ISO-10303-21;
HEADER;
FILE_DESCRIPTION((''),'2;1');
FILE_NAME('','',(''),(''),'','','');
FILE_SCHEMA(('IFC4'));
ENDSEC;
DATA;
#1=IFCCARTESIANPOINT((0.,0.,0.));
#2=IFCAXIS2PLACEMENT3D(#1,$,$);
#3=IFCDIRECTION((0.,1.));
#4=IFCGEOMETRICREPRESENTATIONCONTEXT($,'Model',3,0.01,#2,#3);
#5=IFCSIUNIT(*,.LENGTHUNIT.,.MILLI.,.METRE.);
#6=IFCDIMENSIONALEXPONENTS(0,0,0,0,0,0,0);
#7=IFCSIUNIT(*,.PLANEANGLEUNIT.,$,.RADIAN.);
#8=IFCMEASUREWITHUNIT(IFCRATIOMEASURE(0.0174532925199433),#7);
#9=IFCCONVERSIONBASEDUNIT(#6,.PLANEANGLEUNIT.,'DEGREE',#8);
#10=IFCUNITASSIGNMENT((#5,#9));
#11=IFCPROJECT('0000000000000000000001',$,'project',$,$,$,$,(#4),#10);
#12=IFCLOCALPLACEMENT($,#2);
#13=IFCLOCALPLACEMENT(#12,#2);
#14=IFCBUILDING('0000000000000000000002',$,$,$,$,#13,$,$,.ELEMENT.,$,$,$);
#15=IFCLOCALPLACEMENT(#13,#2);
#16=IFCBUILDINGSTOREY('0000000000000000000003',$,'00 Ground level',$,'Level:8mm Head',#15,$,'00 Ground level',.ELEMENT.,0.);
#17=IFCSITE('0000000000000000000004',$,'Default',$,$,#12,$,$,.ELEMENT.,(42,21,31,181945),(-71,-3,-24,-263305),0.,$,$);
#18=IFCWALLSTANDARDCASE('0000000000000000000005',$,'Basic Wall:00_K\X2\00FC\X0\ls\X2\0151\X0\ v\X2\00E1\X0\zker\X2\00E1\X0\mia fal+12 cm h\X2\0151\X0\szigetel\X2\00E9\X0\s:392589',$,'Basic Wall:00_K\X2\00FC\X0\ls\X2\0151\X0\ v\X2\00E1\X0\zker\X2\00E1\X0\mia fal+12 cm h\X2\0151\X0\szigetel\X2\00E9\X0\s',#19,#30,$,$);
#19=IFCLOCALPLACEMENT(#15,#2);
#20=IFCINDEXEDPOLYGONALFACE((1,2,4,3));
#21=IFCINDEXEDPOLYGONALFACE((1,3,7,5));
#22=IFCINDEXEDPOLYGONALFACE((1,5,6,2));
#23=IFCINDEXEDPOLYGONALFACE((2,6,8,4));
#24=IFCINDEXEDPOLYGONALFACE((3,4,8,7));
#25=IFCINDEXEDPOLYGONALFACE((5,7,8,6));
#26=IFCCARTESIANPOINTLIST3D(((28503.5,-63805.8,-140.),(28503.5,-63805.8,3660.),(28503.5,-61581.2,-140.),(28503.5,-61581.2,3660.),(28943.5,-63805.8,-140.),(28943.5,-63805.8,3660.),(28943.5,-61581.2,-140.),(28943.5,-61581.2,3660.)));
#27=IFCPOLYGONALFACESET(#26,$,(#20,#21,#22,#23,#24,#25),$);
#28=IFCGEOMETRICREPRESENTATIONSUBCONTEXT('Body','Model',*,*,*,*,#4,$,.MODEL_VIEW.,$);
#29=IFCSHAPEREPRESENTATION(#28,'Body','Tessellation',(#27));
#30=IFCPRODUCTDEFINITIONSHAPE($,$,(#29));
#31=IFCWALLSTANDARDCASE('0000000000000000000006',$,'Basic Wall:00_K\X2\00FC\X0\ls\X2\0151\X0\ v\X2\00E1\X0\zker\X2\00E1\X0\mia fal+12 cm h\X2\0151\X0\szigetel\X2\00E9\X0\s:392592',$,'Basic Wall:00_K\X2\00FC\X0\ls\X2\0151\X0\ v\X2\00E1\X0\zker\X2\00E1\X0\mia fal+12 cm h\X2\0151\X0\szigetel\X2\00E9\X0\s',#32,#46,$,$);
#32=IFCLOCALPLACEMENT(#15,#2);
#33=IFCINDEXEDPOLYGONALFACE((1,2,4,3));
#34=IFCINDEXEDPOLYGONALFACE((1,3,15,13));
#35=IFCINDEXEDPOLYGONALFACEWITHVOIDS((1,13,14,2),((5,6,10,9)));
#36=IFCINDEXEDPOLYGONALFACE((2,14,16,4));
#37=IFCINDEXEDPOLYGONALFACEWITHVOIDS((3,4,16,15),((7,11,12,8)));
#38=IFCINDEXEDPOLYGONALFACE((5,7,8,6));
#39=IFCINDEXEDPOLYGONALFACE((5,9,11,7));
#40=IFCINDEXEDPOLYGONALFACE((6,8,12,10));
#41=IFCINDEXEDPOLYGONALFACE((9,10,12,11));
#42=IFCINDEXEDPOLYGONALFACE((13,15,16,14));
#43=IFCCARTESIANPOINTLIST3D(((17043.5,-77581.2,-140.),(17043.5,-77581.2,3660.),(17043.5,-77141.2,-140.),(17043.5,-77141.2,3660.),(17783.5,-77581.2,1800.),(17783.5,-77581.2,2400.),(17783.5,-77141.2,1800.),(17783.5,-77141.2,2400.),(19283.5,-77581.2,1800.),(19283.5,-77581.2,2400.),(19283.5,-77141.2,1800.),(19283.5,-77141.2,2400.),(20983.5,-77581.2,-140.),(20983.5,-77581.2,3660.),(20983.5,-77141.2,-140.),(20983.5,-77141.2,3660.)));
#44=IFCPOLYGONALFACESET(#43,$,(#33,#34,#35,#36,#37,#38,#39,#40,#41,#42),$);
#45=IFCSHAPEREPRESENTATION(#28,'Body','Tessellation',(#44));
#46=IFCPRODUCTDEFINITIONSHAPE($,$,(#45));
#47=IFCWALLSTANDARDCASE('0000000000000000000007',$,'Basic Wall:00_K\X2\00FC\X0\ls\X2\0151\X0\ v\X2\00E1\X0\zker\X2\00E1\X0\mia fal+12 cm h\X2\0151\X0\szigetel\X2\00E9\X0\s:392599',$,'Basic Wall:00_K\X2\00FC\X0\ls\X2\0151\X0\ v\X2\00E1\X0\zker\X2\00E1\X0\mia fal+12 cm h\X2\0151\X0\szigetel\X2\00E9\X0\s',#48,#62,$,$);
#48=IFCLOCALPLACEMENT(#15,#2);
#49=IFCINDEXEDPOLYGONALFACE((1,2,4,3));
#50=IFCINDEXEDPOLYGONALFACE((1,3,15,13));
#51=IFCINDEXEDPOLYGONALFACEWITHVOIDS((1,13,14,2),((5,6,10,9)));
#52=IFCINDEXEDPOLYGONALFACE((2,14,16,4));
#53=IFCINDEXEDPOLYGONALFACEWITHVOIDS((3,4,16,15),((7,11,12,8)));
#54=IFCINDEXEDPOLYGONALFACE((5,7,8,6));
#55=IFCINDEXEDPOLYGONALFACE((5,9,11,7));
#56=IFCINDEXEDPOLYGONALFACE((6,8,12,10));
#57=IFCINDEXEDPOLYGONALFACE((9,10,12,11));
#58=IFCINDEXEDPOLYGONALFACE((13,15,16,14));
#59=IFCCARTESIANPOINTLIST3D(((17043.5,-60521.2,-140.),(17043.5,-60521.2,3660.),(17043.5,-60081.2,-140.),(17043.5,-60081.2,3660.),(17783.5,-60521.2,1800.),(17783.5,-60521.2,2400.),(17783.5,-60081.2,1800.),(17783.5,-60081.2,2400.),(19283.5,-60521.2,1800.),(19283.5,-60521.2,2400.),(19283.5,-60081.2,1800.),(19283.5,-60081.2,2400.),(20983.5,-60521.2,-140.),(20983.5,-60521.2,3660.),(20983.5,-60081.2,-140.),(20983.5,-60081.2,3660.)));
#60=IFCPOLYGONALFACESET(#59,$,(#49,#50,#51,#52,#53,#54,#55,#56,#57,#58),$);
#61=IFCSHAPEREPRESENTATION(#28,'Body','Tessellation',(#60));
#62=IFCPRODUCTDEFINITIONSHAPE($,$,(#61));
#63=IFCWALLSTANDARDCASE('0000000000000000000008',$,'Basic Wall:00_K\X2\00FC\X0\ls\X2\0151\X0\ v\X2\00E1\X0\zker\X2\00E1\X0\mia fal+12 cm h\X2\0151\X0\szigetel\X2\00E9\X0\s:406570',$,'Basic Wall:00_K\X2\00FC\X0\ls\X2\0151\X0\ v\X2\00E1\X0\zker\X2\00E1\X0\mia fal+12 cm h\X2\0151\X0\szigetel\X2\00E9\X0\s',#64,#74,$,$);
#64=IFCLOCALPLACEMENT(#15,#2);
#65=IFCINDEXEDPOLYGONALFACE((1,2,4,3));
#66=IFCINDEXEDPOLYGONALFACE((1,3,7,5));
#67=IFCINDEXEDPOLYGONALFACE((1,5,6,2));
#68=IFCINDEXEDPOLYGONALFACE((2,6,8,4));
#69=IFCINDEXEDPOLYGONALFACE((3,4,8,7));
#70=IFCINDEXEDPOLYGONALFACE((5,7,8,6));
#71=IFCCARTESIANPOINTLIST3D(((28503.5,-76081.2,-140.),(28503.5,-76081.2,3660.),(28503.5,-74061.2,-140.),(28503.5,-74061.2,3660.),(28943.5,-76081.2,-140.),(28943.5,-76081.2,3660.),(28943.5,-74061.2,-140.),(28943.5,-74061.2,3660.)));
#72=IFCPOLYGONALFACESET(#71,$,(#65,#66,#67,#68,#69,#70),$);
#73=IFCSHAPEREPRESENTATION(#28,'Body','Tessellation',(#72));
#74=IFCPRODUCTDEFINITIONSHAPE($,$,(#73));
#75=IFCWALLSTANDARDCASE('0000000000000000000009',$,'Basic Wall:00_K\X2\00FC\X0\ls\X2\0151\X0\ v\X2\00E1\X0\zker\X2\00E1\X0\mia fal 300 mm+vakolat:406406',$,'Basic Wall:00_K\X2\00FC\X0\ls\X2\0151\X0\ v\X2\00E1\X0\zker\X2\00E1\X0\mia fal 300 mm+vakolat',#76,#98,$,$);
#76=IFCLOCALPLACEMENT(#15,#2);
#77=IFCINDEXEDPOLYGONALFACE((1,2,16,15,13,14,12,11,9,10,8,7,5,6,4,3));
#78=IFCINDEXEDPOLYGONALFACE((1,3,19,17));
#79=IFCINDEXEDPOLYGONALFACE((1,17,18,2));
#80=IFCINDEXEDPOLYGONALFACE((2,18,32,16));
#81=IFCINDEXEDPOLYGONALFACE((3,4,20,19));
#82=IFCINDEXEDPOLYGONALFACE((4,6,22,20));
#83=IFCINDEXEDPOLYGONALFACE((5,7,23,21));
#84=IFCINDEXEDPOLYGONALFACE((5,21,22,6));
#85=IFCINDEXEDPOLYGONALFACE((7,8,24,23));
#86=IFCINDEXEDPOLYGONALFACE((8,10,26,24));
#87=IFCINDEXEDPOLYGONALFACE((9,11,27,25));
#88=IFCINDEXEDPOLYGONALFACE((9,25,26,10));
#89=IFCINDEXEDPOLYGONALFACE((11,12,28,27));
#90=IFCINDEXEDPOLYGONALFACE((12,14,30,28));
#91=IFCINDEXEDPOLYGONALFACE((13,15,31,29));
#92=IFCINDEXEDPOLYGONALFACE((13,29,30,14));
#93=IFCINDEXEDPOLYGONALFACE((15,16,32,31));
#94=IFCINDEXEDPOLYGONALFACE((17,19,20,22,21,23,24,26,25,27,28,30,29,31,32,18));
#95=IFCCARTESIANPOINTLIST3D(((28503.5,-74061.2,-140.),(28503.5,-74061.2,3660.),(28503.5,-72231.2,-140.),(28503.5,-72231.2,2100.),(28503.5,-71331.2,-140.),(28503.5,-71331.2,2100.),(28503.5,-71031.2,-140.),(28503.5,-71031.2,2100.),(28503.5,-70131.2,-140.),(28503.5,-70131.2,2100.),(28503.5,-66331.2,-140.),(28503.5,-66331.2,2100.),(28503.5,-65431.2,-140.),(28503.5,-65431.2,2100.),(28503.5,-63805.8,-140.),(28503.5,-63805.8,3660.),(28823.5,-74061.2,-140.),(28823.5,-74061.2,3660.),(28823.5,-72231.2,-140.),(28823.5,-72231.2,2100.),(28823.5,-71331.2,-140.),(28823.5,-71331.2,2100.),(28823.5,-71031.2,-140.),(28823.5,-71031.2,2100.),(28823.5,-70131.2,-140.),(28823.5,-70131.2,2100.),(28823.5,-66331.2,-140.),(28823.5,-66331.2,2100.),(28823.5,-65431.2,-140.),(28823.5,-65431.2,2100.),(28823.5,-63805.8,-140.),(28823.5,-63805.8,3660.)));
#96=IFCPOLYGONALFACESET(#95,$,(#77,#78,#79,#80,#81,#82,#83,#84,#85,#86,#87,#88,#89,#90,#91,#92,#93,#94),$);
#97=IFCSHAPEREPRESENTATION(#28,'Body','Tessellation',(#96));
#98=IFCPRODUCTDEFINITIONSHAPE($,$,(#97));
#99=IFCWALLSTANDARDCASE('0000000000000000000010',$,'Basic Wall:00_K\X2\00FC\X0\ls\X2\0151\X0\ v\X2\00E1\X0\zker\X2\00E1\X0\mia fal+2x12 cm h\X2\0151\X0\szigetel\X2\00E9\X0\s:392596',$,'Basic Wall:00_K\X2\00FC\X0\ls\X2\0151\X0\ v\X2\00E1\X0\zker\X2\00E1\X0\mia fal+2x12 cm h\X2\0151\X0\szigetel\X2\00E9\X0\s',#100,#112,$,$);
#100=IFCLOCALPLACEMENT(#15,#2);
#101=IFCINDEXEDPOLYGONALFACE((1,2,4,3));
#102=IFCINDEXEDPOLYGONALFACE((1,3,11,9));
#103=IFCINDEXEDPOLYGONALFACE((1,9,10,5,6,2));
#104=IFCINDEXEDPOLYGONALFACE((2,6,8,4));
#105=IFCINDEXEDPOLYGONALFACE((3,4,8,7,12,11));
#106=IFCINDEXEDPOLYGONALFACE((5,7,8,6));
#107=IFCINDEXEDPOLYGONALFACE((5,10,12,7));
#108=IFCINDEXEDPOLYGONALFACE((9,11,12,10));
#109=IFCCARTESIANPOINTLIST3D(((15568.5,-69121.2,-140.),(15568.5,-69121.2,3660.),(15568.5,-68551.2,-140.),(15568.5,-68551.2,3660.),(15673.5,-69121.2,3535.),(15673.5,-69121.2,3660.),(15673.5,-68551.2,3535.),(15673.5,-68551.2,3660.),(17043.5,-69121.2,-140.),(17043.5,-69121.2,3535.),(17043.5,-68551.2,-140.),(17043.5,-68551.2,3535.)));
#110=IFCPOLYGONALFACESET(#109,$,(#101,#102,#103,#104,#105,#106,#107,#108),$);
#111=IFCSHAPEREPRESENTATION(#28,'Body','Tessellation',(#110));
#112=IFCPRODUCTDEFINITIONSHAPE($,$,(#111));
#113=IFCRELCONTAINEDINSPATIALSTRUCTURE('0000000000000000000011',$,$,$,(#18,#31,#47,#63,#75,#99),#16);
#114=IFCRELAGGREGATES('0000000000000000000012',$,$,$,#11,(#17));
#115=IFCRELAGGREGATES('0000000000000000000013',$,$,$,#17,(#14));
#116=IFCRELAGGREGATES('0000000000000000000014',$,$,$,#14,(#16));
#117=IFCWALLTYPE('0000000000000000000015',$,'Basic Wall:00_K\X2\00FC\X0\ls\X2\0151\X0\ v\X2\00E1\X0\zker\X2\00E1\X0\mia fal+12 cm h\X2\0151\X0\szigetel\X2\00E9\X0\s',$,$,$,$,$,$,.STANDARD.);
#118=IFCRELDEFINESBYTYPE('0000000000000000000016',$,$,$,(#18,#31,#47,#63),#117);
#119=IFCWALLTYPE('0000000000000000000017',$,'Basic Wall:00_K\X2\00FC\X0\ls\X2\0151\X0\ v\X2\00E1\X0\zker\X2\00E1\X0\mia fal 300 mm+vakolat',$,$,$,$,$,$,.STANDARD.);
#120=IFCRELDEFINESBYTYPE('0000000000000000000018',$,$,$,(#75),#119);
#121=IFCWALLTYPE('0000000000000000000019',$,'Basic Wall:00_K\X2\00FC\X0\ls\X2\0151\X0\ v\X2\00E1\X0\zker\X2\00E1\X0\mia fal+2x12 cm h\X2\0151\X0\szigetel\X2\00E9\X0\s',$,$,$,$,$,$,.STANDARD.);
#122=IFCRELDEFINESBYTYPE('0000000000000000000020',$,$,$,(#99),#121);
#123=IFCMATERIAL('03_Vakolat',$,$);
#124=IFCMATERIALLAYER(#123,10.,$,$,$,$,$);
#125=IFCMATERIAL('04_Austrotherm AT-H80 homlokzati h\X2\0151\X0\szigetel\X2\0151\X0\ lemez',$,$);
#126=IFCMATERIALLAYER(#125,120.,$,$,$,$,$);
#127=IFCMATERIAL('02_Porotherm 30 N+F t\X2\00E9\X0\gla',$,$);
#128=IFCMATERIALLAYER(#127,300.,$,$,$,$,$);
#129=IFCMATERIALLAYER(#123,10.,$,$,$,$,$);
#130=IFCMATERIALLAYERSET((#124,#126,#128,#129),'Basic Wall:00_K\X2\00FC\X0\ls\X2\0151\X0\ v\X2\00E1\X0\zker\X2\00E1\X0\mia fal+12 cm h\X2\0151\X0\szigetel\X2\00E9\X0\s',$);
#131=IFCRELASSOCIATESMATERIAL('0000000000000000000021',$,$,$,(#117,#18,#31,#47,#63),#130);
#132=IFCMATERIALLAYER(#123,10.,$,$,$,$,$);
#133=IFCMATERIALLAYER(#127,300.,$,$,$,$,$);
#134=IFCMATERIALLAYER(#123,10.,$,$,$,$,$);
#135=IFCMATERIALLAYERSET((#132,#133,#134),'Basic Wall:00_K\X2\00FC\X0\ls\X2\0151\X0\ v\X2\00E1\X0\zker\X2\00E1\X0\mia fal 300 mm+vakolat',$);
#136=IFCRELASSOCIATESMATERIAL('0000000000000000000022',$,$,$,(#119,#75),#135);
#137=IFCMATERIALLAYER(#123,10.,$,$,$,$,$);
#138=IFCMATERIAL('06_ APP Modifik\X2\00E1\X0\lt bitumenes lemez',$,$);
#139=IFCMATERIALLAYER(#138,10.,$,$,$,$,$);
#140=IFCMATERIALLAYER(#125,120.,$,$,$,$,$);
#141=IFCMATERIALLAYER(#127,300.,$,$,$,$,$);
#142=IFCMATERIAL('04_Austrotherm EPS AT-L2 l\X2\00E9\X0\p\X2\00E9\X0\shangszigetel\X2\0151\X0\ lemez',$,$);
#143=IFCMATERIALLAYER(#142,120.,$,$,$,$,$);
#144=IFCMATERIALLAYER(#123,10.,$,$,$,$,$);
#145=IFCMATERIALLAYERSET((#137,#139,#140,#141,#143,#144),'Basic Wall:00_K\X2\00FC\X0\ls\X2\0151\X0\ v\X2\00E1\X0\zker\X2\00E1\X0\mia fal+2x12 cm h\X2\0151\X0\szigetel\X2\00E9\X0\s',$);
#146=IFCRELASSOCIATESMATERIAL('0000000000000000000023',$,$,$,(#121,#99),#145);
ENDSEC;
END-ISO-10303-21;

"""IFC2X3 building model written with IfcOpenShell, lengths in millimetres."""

from ifc_helpers import new_model, entity, si_unit, converted_unit, direction, frame, frame_2d, origin, origin_2d_with_axis, place, context, subcontext, project, spatial, polyline, rectangle, extrude, clip, bounded_halfspace, material, layer, layer_set, layer_usage, type_object, element, save


model = new_model("IFC2X3")

# Units and contexts
model_context = context("Model", 3, precision=0.01, world=origin(), true_north=direction((0.0, 1.0)))
body_context = subcontext(model_context, "Body", "Model", "MODEL_VIEW")
ifc_project = project(units=[si_unit("LENGTHUNIT", "METRE", prefix="MILLI"), converted_unit("PLANEANGLEUNIT", "DEGREE", entity("IfcRatioMeasure", 0.0174532925199433), si_unit("PLANEANGLEUNIT", "RADIAN"), dimensions=[0, 0, 0, 0, 0, 0, 0])], contexts=[model_context])

# Site, building, storey
site_placement = place(None, origin())
site = spatial("IfcSite", under=ifc_project, at=site_placement, Name="Default", CompositionType="ELEMENT", RefLatitude=(42, 21, 31, 181945), RefLongitude=(-71, -3, -24, -263305), RefElevation=0.0)
building_placement = place(site_placement, origin())
building = spatial("IfcBuilding", under=site, at=building_placement, CompositionType="ELEMENT")
storey_placement = place(building_placement, origin())
storey = spatial("IfcBuildingStorey", under=building, at=storey_placement, Name="00 Ground level", ObjectType="Level:8mm Head", LongName="00 Ground level", CompositionType="ELEMENT", Elevation=0.0)

# Wall
ifc_material_1 = material(Name="03_Vakolat")
ifc_layer_1 = layer(ifc_material_1, 10.0)
ifc_material_2 = material(Name="04_Austrotherm AT-H80 homlokzati hőszigetelő lemez")
ifc_layer_2 = layer(ifc_material_2, 120.0)
ifc_material_3 = material(Name="02_Porotherm 30 N+F tégla")
ifc_layer_3 = layer(ifc_material_3, 300.0)
ifc_layer_4 = layer(ifc_material_1, 10.0)
ifc_layer_set_1 = layer_set([ifc_layer_1, ifc_layer_2, ifc_layer_3, ifc_layer_4], Name="Basic Wall:00_Külső vázkerámia fal+12 cm hőszigetelés")
ifc_layer_usage_1 = layer_usage(ifc_layer_set_1, "AXIS2", "NEGATIVE", 220.0)
wall_type_1 = type_object("IfcWallType", Name="Basic Wall:00_Külső vázkerámia fal+12 cm hőszigetelés", PredefinedType="STANDARD", material=ifc_layer_set_1)
wall_1_placement = place(storey_placement, frame((28723.5, -61581.2, -140.0), z_axis=(0.0, 0.0, 1.0), x_axis=(0.0, -1.0, 0.0)))
element("IfcWallStandardCase", 1, at=wall_1_placement, inside=storey, type_object=wall_type_1, material=ifc_layer_usage_1, Name="Basic Wall:00_Külső vázkerámia fal+12 cm hőszigetelés:392589", ObjectType="Basic Wall:00_Külső vázkerámia fal+12 cm hőszigetelés", context=body_context, shape_type="SweptSolid", body=[
    extrude(rectangle(XDim=2224.6, YDim=440.0, at=frame_2d((1112.3, 0.0), x_axis=(-1.0, 0.0))), origin(), (0.0, 0.0, 1.0), 3800.0),
])

# Walls, openings
ifc_layer_usage_2 = layer_usage(ifc_layer_set_1, "AXIS2", "NEGATIVE", 220.0)
wall_2_placement = place(storey_placement, frame((20983.5, -77361.2, -140.0), z_axis=(0.0, 0.0, 1.0), x_axis=(-1.0, 0.0, 0.0)))
wall_2 = element("IfcWallStandardCase", 2, at=wall_2_placement, inside=storey, type_object=wall_type_1, material=ifc_layer_usage_2, Name="Basic Wall:00_Külső vázkerámia fal+12 cm hőszigetelés:392592", ObjectType="Basic Wall:00_Külső vázkerámia fal+12 cm hőszigetelés", context=body_context, shape_type="SweptSolid", body=[
    extrude(rectangle(XDim=3940.0, YDim=440.0, at=frame_2d((1970.0, 0.0), x_axis=(-1.0, 0.0))), origin(), (0.0, 0.0, 1.0), 3800.0),
])
opening_1_placement = place(wall_2_placement, frame((3200.0, 1744.0, 1940.0), z_axis=(0.0, 0.0, 1.0), x_axis=(-1.0, 0.0, 0.0)))
element("IfcOpeningElement", 3, at=opening_1_placement, cuts=wall_2, ObjectType="Opening", context=body_context, shape_type="SweptSolid", body=[
    extrude(rectangle(XDim=600.0, YDim=1500.0, at=frame_2d((0.0, 0.0), x_axis=(0.0, 1.0))), frame((750.0, 3048.0, 300.0), z_axis=(0.0, -1.0, 0.0), x_axis=(1.0, 0.0, 0.0)), (0.0, 0.0, 1.0), 3048.0),
])
ifc_layer_usage_3 = layer_usage(ifc_layer_set_1, "AXIS2", "POSITIVE", -220.0)
wall_3_placement = place(storey_placement, frame((20983.5, -60301.2, -140.0), z_axis=(0.0, 0.0, 1.0), x_axis=(-1.0, 0.0, 0.0)))
wall_3 = element("IfcWallStandardCase", 4, at=wall_3_placement, inside=storey, type_object=wall_type_1, material=ifc_layer_usage_3, Name="Basic Wall:00_Külső vázkerámia fal+12 cm hőszigetelés:392599", ObjectType="Basic Wall:00_Külső vázkerámia fal+12 cm hőszigetelés", context=body_context, shape_type="SweptSolid", body=[
    extrude(rectangle(XDim=3940.0, YDim=440.0, at=frame_2d((1970.0, 0.0), x_axis=(-1.0, 0.0))), origin(), (0.0, 0.0, 1.0), 3800.0),
])
opening_2_placement = place(wall_3_placement, frame((3200.0, 1304.0, 1940.0), z_axis=(0.0, 0.0, 1.0), x_axis=(-1.0, 0.0, 0.0)))
element("IfcOpeningElement", 5, at=opening_2_placement, cuts=wall_3, ObjectType="Opening", context=body_context, shape_type="SweptSolid", body=[
    extrude(rectangle(XDim=600.0, YDim=1500.0, at=frame_2d((0.0, 0.0), x_axis=(0.0, 1.0))), frame((750.0, 3048.0, 300.0), z_axis=(0.0, -1.0, 0.0), x_axis=(1.0, 0.0, 0.0)), (0.0, 0.0, 1.0), 3048.0),
])

# Wall
ifc_layer_usage_4 = layer_usage(ifc_layer_set_1, "AXIS2", "NEGATIVE", 220.0)
wall_4_placement = place(storey_placement, frame((28723.5, -74061.2, -140.0), z_axis=(0.0, 0.0, 1.0), x_axis=(0.0, -1.0, 0.0)))
element("IfcWallStandardCase", 6, at=wall_4_placement, inside=storey, type_object=wall_type_1, material=ifc_layer_usage_4, Name="Basic Wall:00_Külső vázkerámia fal+12 cm hőszigetelés:406570", ObjectType="Basic Wall:00_Külső vázkerámia fal+12 cm hőszigetelés", context=body_context, shape_type="SweptSolid", body=[
    extrude(rectangle(XDim=2020.0, YDim=440.0, at=frame_2d((1010.0, 0.0), x_axis=(-1.0, 0.0))), origin(), (0.0, 0.0, 1.0), 3800.0),
])

# Wall, openings
ifc_layer_5 = layer(ifc_material_1, 10.0)
ifc_layer_6 = layer(ifc_material_3, 300.0)
ifc_layer_7 = layer(ifc_material_1, 10.0)
ifc_layer_set_2 = layer_set([ifc_layer_5, ifc_layer_6, ifc_layer_7], Name="Basic Wall:00_Külső vázkerámia fal 300 mm+vakolat")
ifc_layer_usage_5 = layer_usage(ifc_layer_set_2, "AXIS2", "NEGATIVE", 160.0)
wall_type_2 = type_object("IfcWallType", Name="Basic Wall:00_Külső vázkerámia fal 300 mm+vakolat", PredefinedType="STANDARD", material=ifc_layer_set_2)
wall_5_placement = place(storey_placement, frame((28663.5, -63805.8, -140.0), z_axis=(0.0, 0.0, 1.0), x_axis=(0.0, -1.0, 0.0)))
wall_5 = element("IfcWallStandardCase", 7, at=wall_5_placement, inside=storey, type_object=wall_type_2, material=ifc_layer_usage_5, Name="Basic Wall:00_Külső vázkerámia fal 300 mm+vakolat:406406", ObjectType="Basic Wall:00_Külső vázkerámia fal 300 mm+vakolat", context=body_context, shape_type="SweptSolid", body=[
    extrude(rectangle(XDim=10255.4, YDim=320.0, at=frame_2d((5127.7, 0.0), x_axis=(-1.0, 0.0))), origin(), (0.0, 0.0, 1.0), 3800.0),
])
opening_3_placement = place(wall_5_placement, frame((8425.4, -1364.0, 0.0), z_axis=(0.0, 0.0, 1.0), x_axis=(0.0, 1.0, 0.0)))
element("IfcOpeningElement", 8, at=opening_3_placement, cuts=wall_5, ObjectType="Opening", context=body_context, shape_type="SweptSolid", body=[
    extrude(rectangle(XDim=2240.0, YDim=900.0, at=frame_2d((0.0, 0.0), x_axis=(0.0, 1.0))), frame((0.0, 450.0, 1120.0), z_axis=(1.0, 0.0, 0.0), x_axis=(0.0, 1.0, 0.0)), (0.0, 0.0, 1.0), 3048.0),
])
opening_4_placement = place(wall_5_placement, frame((7225.4, -1364.0, 0.0), z_axis=(0.0, 0.0, 1.0), x_axis=(0.0, 1.0, 0.0)))
element("IfcOpeningElement", 9, at=opening_4_placement, cuts=wall_5, ObjectType="Opening", context=body_context, shape_type="SweptSolid", body=[
    extrude(rectangle(XDim=2240.0, YDim=900.0, at=origin_2d_with_axis()), frame((0.0, 450.0, 1120.0), z_axis=(1.0, 0.0, 0.0), x_axis=(0.0, 0.0, 1.0)), (0.0, 0.0, 1.0), 3048.0),
])
opening_5_placement = place(wall_5_placement, frame((2525.4, -1364.0, 0.0), z_axis=(0.0, 0.0, 1.0), x_axis=(0.0, 1.0, 0.0)))
element("IfcOpeningElement", 10, at=opening_5_placement, cuts=wall_5, ObjectType="Opening", context=body_context, shape_type="SweptSolid", body=[
    extrude(rectangle(XDim=2240.0, YDim=900.0, at=origin_2d_with_axis()), frame((0.0, 450.0, 1120.0), z_axis=(1.0, 0.0, 0.0), x_axis=(0.0, 0.0, 1.0)), (0.0, 0.0, 1.0), 3048.0),
])

# Wall
ifc_layer_8 = layer(ifc_material_1, 10.0)
ifc_material_4 = material(Name="06_ APP Modifikált bitumenes lemez")
ifc_layer_9 = layer(ifc_material_4, 10.0)
ifc_layer_10 = layer(ifc_material_2, 120.0)
ifc_layer_11 = layer(ifc_material_3, 300.0)
ifc_material_5 = material(Name="04_Austrotherm EPS AT-L2 lépéshangszigetelő lemez")
ifc_layer_12 = layer(ifc_material_5, 120.0)
ifc_layer_13 = layer(ifc_material_1, 10.0)
ifc_layer_set_3 = layer_set([ifc_layer_8, ifc_layer_9, ifc_layer_10, ifc_layer_11, ifc_layer_12, ifc_layer_13], Name="Basic Wall:00_Külső vázkerámia fal+2x12 cm hőszigetelés")
ifc_layer_usage_6 = layer_usage(ifc_layer_set_3, "AXIS2", "NEGATIVE", 285.0)
wall_type_3 = type_object("IfcWallType", Name="Basic Wall:00_Külső vázkerámia fal+2x12 cm hőszigetelés", PredefinedType="STANDARD", material=ifc_layer_set_3)
wall_6_placement = place(storey_placement, frame((17043.5, -68836.2, -140.0), z_axis=(0.0, 0.0, 1.0), x_axis=(-1.0, 0.0, 0.0)))
element("IfcWallStandardCase", 11, at=wall_6_placement, inside=storey, type_object=wall_type_3, material=ifc_layer_usage_6, Name="Basic Wall:00_Külső vázkerámia fal+2x12 cm hőszigetelés:392596", ObjectType="Basic Wall:00_Külső vázkerámia fal+2x12 cm hőszigetelés", context=body_context, shape_type="Clipping", body=[
    clip(clip(extrude(rectangle(XDim=1475.0, YDim=570.0, at=frame_2d((737.5, 0.0), x_axis=(-1.0, 0.0))), origin(), (0.0, 0.0, 1.0), 3800.0), bounded_halfspace(frame((1370.0, -285.0, 3675.0), z_axis=(0.0, 0.0, -1.0), x_axis=(-1.0, 0.0, 0.0)), True, frame((1370.0, -285.0, 3675.0), z_axis=(0.0, 0.0, -1.0), x_axis=(-1.0, 0.0, 0.0)), polyline([(0.0, 0.0), (1370.0, 0.0), (1370.0, 570.0), (0.0, 570.0), (0.0, 0.0)]))), bounded_halfspace(frame((1370.0, 285.0, 3675.0), z_axis=(1.0, 0.0, 0.0), x_axis=(0.0, 0.0, 1.0)), True, frame((1370.0, 285.0, 3675.0), z_axis=(1.0, 0.0, 0.0), x_axis=(0.0, 0.0, 1.0)), polyline([(0.0, 0.0), (125.0, 0.0), (125.0, 570.0), (0.0, 570.0), (0.0, 0.0)]))),
])

save(model, "model.ifc")
